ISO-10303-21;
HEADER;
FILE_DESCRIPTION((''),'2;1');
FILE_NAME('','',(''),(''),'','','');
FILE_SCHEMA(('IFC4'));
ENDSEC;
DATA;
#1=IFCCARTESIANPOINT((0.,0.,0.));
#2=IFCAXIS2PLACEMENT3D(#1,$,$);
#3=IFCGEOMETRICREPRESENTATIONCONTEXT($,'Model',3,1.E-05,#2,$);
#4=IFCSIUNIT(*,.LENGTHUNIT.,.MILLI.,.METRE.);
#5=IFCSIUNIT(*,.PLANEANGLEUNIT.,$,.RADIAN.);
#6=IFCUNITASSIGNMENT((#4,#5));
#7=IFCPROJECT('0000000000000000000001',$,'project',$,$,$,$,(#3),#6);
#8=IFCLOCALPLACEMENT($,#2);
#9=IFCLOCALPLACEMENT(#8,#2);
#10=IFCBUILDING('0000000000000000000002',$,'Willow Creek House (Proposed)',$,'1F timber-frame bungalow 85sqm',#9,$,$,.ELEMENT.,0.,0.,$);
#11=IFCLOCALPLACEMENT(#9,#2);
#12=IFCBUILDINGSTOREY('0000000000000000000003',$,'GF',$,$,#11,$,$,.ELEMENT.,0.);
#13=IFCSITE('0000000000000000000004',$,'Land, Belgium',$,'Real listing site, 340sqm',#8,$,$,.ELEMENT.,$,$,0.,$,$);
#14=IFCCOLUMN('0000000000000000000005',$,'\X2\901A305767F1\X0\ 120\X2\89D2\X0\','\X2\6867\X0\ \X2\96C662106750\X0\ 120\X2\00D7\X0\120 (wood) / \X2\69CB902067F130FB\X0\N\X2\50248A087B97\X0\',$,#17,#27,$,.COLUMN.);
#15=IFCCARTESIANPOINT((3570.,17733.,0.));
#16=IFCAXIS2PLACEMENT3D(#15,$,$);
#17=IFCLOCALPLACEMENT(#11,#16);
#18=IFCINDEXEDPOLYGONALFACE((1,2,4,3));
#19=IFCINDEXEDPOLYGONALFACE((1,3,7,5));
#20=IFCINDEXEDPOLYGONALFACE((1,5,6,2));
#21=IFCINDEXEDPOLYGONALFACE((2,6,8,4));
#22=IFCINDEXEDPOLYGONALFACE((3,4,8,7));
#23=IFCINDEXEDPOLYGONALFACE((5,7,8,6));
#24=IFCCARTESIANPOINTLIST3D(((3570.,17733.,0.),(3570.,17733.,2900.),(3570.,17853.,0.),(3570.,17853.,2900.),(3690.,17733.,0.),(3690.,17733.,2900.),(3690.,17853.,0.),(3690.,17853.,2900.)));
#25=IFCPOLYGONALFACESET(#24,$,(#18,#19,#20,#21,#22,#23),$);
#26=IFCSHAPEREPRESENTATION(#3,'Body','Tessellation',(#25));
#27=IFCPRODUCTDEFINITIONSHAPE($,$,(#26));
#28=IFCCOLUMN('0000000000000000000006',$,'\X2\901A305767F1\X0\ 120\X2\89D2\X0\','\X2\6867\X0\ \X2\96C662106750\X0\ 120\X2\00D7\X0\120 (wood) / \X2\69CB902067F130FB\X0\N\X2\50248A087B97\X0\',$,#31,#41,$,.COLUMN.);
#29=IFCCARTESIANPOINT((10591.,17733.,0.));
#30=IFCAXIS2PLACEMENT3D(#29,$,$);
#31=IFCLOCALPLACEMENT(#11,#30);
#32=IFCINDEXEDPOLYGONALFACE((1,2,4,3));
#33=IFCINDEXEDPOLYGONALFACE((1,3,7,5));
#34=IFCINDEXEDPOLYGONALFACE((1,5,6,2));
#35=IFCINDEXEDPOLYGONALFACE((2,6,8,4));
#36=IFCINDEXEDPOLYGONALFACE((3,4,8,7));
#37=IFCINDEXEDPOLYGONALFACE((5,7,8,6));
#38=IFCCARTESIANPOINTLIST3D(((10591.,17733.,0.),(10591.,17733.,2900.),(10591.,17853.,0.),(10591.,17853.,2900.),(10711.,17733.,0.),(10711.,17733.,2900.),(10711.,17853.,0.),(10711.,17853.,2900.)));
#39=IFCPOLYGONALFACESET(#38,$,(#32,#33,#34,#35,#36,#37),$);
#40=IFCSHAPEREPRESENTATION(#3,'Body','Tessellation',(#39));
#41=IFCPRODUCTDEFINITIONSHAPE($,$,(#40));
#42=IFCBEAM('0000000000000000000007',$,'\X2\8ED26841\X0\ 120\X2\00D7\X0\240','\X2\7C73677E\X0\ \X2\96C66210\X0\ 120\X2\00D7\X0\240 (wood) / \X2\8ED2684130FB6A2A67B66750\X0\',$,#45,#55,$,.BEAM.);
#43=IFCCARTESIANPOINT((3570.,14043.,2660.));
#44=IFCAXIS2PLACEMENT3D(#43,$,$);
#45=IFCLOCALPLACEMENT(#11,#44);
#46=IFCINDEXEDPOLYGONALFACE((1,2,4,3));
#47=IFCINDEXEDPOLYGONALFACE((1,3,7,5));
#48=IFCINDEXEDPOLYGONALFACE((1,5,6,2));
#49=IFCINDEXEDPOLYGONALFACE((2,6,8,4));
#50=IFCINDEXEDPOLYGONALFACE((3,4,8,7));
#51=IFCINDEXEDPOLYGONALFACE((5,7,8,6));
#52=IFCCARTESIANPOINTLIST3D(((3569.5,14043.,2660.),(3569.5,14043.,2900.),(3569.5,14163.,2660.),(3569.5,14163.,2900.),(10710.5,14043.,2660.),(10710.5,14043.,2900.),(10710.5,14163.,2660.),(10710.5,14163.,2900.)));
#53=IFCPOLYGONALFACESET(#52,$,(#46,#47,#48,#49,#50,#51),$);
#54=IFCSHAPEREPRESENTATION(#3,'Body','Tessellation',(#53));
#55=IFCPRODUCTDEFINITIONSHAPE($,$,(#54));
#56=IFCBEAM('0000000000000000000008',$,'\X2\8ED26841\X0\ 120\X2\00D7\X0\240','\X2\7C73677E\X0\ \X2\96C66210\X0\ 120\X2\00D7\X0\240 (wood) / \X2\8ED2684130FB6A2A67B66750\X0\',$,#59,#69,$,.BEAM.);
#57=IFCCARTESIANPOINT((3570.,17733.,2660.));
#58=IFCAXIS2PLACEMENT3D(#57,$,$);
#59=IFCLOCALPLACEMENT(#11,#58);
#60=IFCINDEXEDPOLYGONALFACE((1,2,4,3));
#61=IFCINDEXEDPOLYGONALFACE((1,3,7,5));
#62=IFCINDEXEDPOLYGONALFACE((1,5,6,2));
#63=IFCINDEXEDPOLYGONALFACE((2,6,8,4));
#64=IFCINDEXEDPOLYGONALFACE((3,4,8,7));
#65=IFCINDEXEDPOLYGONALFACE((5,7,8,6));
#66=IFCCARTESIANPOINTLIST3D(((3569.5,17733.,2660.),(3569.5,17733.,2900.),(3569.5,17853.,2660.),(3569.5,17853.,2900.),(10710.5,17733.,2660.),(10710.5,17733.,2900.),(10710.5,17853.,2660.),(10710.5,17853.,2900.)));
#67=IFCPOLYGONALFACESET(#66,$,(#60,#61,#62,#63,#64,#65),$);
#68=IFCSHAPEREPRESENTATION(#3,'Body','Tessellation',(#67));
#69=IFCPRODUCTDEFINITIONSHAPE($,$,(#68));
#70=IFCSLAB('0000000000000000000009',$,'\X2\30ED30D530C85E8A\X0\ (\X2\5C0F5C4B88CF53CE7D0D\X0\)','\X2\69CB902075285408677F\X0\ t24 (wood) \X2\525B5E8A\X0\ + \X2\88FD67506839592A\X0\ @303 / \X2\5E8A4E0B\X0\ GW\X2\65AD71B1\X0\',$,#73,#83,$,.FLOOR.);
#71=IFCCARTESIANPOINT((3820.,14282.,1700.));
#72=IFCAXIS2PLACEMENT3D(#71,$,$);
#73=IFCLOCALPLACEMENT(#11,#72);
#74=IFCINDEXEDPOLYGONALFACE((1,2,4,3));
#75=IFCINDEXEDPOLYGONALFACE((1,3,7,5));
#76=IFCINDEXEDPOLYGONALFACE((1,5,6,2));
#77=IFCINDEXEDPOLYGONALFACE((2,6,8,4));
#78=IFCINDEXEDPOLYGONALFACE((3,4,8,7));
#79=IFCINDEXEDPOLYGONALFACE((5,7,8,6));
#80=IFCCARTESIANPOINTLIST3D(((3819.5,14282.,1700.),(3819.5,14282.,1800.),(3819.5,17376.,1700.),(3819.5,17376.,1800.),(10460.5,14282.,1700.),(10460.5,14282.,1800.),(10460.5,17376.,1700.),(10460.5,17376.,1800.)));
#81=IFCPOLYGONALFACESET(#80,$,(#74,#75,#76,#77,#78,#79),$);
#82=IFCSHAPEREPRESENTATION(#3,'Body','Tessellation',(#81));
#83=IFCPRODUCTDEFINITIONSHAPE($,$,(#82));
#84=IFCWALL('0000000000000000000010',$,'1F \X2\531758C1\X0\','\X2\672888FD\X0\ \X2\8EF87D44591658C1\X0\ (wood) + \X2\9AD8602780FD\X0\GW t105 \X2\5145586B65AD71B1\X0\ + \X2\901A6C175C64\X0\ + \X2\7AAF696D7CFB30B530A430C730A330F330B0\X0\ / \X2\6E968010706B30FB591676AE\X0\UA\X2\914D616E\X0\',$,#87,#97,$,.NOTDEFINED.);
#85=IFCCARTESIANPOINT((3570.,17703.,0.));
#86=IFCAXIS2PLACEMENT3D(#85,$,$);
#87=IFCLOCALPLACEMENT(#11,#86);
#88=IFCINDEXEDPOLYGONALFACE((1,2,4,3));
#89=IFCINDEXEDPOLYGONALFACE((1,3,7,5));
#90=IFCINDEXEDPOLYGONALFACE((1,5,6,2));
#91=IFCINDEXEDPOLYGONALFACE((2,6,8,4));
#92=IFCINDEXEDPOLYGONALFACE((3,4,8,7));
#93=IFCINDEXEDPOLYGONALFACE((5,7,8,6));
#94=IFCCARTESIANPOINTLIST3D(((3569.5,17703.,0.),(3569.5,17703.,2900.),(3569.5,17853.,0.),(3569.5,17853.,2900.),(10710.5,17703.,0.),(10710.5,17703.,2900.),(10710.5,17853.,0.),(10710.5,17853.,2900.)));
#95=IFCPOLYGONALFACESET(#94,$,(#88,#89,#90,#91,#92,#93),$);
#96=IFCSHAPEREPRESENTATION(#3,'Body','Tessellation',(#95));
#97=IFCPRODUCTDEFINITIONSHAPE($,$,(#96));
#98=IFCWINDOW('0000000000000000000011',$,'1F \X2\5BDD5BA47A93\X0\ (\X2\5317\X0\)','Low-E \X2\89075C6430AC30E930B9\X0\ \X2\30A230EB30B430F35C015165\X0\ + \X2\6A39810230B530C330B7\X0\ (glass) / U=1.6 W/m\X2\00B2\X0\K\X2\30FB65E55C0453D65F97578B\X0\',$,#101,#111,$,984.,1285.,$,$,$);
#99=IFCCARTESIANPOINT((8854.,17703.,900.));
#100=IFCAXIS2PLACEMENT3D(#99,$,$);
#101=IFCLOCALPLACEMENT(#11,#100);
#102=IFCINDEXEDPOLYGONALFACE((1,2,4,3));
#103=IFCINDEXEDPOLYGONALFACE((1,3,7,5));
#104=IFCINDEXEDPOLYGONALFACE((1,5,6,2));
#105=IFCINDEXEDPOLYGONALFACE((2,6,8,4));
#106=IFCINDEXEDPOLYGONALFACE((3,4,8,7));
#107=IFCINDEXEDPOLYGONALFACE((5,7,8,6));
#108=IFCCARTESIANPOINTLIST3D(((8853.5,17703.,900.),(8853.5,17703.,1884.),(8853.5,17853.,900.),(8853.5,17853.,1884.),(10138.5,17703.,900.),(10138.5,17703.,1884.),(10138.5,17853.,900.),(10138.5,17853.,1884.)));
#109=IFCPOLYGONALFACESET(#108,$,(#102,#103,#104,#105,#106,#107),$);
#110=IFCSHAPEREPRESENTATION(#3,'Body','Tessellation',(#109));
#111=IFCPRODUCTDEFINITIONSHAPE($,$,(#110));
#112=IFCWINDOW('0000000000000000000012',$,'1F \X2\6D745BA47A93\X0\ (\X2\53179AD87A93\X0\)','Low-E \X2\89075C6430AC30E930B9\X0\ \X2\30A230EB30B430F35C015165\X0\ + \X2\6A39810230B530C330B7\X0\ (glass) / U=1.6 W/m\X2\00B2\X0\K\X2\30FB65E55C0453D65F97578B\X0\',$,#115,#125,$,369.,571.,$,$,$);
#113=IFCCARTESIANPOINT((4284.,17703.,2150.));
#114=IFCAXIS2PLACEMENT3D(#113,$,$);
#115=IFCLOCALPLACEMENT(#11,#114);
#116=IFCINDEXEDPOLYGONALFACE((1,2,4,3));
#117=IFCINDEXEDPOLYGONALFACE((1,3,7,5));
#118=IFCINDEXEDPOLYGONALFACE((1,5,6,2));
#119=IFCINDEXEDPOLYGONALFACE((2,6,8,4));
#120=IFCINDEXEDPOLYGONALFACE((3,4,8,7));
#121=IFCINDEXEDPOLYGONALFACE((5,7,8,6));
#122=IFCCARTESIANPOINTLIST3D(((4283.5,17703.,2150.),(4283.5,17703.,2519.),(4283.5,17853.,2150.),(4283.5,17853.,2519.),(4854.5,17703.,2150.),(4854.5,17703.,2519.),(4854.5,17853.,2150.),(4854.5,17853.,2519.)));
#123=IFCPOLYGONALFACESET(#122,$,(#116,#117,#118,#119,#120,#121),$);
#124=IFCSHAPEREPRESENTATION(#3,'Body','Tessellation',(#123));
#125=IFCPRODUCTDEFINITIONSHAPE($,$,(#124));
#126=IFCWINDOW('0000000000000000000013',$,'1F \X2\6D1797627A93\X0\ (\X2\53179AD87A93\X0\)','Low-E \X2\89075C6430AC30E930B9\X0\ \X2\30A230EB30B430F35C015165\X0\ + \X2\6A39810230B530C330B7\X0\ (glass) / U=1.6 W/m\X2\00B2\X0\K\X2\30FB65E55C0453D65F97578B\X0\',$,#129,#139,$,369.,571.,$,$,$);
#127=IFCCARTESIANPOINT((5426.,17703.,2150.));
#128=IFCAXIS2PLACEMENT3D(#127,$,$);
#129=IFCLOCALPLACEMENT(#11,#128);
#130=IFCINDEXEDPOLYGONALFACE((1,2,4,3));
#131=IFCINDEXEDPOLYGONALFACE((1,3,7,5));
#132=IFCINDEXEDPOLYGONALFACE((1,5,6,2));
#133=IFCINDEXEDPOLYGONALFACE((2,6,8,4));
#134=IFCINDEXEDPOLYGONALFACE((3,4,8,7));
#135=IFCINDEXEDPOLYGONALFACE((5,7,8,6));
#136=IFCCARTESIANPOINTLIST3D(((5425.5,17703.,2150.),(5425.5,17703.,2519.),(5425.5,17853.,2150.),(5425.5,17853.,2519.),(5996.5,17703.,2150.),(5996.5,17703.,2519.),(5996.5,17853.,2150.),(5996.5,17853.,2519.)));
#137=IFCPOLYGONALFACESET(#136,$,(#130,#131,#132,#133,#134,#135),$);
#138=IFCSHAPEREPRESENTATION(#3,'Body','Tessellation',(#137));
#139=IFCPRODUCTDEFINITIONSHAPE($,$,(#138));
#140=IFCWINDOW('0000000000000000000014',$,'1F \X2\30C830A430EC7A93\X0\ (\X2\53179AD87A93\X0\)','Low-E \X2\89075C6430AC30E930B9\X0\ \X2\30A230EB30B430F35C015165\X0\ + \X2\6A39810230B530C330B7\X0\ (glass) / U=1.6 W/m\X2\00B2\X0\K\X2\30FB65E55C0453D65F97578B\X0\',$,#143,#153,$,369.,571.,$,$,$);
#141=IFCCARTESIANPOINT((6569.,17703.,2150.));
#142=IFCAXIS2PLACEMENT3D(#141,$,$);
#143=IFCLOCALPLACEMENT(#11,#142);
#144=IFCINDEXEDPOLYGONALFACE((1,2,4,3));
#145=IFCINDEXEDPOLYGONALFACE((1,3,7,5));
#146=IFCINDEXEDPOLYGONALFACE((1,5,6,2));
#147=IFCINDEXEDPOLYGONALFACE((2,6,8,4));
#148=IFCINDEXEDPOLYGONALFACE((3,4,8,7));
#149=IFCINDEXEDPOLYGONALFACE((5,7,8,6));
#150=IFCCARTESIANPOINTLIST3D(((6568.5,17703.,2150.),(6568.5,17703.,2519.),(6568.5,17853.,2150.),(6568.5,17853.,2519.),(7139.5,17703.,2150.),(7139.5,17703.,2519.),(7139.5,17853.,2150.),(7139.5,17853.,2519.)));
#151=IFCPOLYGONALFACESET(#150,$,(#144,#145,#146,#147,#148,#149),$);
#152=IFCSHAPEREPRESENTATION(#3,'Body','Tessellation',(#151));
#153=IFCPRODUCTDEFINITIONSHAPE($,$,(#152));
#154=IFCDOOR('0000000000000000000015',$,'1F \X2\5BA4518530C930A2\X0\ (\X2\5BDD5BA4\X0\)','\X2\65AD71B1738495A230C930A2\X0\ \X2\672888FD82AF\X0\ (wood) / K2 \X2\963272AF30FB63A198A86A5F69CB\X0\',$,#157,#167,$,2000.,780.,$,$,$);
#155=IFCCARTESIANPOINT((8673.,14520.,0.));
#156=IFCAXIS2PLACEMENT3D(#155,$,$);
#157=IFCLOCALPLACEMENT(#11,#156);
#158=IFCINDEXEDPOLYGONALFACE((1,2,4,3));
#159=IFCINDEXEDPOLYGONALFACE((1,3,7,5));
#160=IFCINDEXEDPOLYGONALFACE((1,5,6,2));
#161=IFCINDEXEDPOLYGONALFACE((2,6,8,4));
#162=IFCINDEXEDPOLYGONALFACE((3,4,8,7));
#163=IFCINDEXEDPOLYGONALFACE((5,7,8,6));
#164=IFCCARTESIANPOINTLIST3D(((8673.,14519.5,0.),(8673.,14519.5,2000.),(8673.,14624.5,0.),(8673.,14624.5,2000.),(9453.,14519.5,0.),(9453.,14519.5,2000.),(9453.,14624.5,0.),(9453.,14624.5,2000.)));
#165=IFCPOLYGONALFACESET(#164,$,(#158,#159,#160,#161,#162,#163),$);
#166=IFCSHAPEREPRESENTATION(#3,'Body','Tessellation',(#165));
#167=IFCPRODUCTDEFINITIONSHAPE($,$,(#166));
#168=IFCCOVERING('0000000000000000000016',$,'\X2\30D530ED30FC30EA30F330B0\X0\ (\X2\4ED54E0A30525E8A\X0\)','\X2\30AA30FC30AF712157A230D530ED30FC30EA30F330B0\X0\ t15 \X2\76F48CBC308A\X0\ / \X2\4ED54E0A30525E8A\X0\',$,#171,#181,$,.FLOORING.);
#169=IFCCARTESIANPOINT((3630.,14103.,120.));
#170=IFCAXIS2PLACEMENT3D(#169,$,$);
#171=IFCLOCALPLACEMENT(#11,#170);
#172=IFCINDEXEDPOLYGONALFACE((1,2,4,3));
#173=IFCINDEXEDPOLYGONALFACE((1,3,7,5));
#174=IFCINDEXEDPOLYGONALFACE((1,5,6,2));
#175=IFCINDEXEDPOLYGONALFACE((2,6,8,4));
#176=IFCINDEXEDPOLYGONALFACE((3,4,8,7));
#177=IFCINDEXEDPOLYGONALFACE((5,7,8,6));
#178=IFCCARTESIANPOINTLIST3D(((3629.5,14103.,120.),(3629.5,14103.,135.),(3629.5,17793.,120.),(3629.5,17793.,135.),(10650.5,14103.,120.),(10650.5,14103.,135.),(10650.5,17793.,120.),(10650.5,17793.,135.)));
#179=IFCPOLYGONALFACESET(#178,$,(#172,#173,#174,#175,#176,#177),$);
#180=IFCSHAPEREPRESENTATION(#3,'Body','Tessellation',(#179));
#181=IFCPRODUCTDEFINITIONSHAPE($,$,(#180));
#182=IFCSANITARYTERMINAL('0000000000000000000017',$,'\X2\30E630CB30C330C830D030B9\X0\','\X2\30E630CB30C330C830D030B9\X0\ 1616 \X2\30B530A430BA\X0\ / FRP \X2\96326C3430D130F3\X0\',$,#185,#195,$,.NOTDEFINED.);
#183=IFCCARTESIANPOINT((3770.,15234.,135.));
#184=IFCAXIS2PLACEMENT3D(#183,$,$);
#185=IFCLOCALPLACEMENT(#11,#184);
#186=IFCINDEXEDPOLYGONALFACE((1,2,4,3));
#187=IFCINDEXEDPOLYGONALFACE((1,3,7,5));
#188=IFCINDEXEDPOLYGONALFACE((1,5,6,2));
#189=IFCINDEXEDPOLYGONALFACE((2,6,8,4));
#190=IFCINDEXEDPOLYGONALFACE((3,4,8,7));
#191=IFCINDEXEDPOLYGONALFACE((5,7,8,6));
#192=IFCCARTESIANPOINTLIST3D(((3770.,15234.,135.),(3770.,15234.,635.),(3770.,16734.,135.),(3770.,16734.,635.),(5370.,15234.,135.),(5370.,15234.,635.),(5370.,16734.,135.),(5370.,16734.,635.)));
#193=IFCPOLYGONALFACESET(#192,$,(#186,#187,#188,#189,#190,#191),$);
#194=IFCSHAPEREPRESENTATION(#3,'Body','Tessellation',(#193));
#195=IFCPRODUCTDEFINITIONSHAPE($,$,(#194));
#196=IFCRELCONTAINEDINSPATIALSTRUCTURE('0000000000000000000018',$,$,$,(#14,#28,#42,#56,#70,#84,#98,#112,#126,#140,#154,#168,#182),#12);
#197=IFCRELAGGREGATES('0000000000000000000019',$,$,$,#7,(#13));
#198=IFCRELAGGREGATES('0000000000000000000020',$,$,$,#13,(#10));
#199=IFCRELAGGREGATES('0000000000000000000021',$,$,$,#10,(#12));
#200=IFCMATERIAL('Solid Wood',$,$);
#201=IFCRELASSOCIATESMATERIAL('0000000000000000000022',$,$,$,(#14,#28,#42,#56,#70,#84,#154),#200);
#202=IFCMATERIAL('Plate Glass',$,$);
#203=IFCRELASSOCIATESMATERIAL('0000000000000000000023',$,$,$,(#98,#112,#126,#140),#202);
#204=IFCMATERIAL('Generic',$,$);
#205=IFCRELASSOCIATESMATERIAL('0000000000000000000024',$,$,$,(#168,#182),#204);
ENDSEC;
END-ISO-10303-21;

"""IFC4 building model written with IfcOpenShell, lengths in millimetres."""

from ifc_helpers import new_model, si_unit, frame, frame_2d, origin, place, context, project, spatial, rectangle, extrude, material, element, fill, save


model = new_model("IFC4")

# Units and contexts
model_context = context("Model", 3, precision=1e-05, world=origin())
ifc_project = project(units=[si_unit("LENGTHUNIT", "METRE", prefix="MILLI"), si_unit("PLANEANGLEUNIT", "RADIAN")], contexts=[model_context])

# Site, building, storey
site_placement = place(None, origin())
site = spatial("IfcSite", under=ifc_project, at=site_placement, Name="Land, Belgium", ObjectType="Real listing site, 340sqm", CompositionType="ELEMENT", RefElevation=0.0)
building_placement = place(site_placement, origin())
building = spatial("IfcBuilding", under=site, at=building_placement, Name="Willow Creek House (Proposed)", ObjectType="1F timber-frame bungalow 85sqm", CompositionType="ELEMENT", ElevationOfRefHeight=0.0, ElevationOfTerrain=0.0)
storey_placement = place(building_placement, origin())
storey = spatial("IfcBuildingStorey", under=building, at=storey_placement, Name="GF", CompositionType="ELEMENT", Elevation=0.0)

# Columns
ifc_material_1 = material(Name="Solid Wood")
column_1_placement = place(storey_placement, frame((3570.0, 17733.0, 0.0)))
element("IfcColumn", 1, at=column_1_placement, inside=storey, material=ifc_material_1, Name="通し柱 120角", Description="桧 集成材 120×120 (wood) / 構造柱・N値計算", PredefinedType="COLUMN", context=model_context, shape_type="SweptSolid", body=[
    extrude(rectangle(XDim=120.0, YDim=120.0, at=frame_2d((60.0, 60.0))), frame((3570.0, 17733.0, 0.0)), (0.0, 0.0, 1.0), 2900.0),
])
column_2_placement = place(storey_placement, frame((10591.0, 17733.0, 0.0)))
element("IfcColumn", 2, at=column_2_placement, inside=storey, material=ifc_material_1, Name="通し柱 120角", Description="桧 集成材 120×120 (wood) / 構造柱・N値計算", PredefinedType="COLUMN", context=model_context, shape_type="SweptSolid", body=[
    extrude(rectangle(XDim=120.0, YDim=120.0, at=frame_2d((60.0, 60.0))), frame((10591.0, 17733.0, 0.0)), (0.0, 0.0, 1.0), 2900.0),
])

# Beams
beam_1_placement = place(storey_placement, frame((3570.0, 14043.0, 2660.0)))
element("IfcBeam", 3, at=beam_1_placement, inside=storey, material=ifc_material_1, Name="軒桁 120×240", Description="米松 集成 120×240 (wood) / 軒桁・横架材", PredefinedType="BEAM", context=model_context, shape_type="SweptSolid", body=[
    extrude(rectangle(XDim=7141.0, YDim=120.0, at=frame_2d((3570.0, 60.0))), frame((3570.0, 14043.0, 2660.0)), (0.0, 0.0, 1.0), 240.0),
])
beam_2_placement = place(storey_placement, frame((3570.0, 17733.0, 2660.0)))
element("IfcBeam", 4, at=beam_2_placement, inside=storey, material=ifc_material_1, Name="軒桁 120×240", Description="米松 集成 120×240 (wood) / 軒桁・横架材", PredefinedType="BEAM", context=model_context, shape_type="SweptSolid", body=[
    extrude(rectangle(XDim=7141.0, YDim=120.0, at=frame_2d((3570.0, 60.0))), frame((3570.0, 17733.0, 2660.0)), (0.0, 0.0, 1.0), 240.0),
])

# Slab
slab_placement = place(storey_placement, frame((3820.0, 14282.0, 1700.0)))
element("IfcSlab", 5, at=slab_placement, inside=storey, material=ifc_material_1, Name="ロフト床 (小屋裏収納)", Description="構造用合板 t24 (wood) 剛床 + 製材根太 @303 / 床下 GW断熱", PredefinedType="FLOOR", context=model_context, shape_type="SweptSolid", body=[
    extrude(rectangle(XDim=6641.0, YDim=3094.0, at=frame_2d((3320.0, 1547.0))), frame((3820.0, 14282.0, 1700.0)), (0.0, 0.0, 1.0), 100.0),
])

# Wall, openings, windows
wall_1_placement = place(storey_placement, frame((3570.0, 17703.0, 0.0)))
wall_1 = element("IfcWall", 6, at=wall_1_placement, inside=storey, material=ifc_material_1, Name="1F 北壁", Description="木製 軸組外壁 (wood) + 高性能GW t105 充填断熱 + 通気層 + 窯業系サイディング / 準耐火・外皮UA配慮", PredefinedType="NOTDEFINED", context=model_context, shape_type="SweptSolid", body=[
    extrude(rectangle(XDim=7141.0, YDim=150.0, at=frame_2d((3570.0, 75.0))), frame((3570.0, 17703.0, 0.0)), (0.0, 0.0, 1.0), 2900.0),
])
opening_1_placement = place(storey_placement, frame((8854.0, 17703.0, 900.0)))
opening_1 = element("IfcOpeningElement", 7, at=opening_1_placement, cuts=wall_1, PredefinedType="NOTDEFINED", context=model_context, shape_type="SweptSolid", body=[
    extrude(rectangle(XDim=1285.0, YDim=150.0, at=frame_2d((642.0, 75.0))), frame((8854.0, 17703.0, 900.0)), (0.0, 0.0, 1.0), 984.0),
])
opening_2_placement = place(storey_placement, frame((4284.0, 17703.0, 2150.0)))
opening_2 = element("IfcOpeningElement", 8, at=opening_2_placement, cuts=wall_1, PredefinedType="NOTDEFINED", context=model_context, shape_type="SweptSolid", body=[
    extrude(rectangle(XDim=571.0, YDim=150.0, at=frame_2d((285.0, 75.0))), frame((4284.0, 17703.0, 2150.0)), (0.0, 0.0, 1.0), 369.0),
])
opening_3_placement = place(storey_placement, frame((5426.0, 17703.0, 2150.0)))
opening_3 = element("IfcOpeningElement", 9, at=opening_3_placement, cuts=wall_1, PredefinedType="NOTDEFINED", context=model_context, shape_type="SweptSolid", body=[
    extrude(rectangle(XDim=571.0, YDim=150.0, at=frame_2d((285.0, 75.0))), frame((5426.0, 17703.0, 2150.0)), (0.0, 0.0, 1.0), 369.0),
])
opening_4_placement = place(storey_placement, frame((6569.0, 17703.0, 2150.0)))
opening_4 = element("IfcOpeningElement", 10, at=opening_4_placement, cuts=wall_1, PredefinedType="NOTDEFINED", context=model_context, shape_type="SweptSolid", body=[
    extrude(rectangle(XDim=571.0, YDim=150.0, at=frame_2d((285.0, 75.0))), frame((6569.0, 17703.0, 2150.0)), (0.0, 0.0, 1.0), 369.0),
])
ifc_material_2 = material(Name="Plate Glass")
window_1_placement = place(storey_placement, frame((8854.0, 17703.0, 900.0)))
window_1 = element("IfcWindow", 11, at=window_1_placement, inside=storey, material=ifc_material_2, Name="1F 寝室窓 (北)", Description="Low-E 複層ガラス アルゴン封入 + 樹脂サッシ (glass) / U=1.6 W/m²K・日射取得型", OverallHeight=984.0, OverallWidth=1285.0, context=model_context, shape_type="SweptSolid", body=[
    extrude(rectangle(XDim=1285.0, YDim=150.0, at=frame_2d((642.0, 75.0))), frame((8854.0, 17703.0, 900.0)), (0.0, 0.0, 1.0), 984.0),
])
fill(opening_1, window_1)
window_2_placement = place(storey_placement, frame((4284.0, 17703.0, 2150.0)))
window_2 = element("IfcWindow", 12, at=window_2_placement, inside=storey, material=ifc_material_2, Name="1F 浴室窓 (北高窓)", Description="Low-E 複層ガラス アルゴン封入 + 樹脂サッシ (glass) / U=1.6 W/m²K・日射取得型", OverallHeight=369.0, OverallWidth=571.0, context=model_context, shape_type="SweptSolid", body=[
    extrude(rectangle(XDim=571.0, YDim=150.0, at=frame_2d((285.0, 75.0))), frame((4284.0, 17703.0, 2150.0)), (0.0, 0.0, 1.0), 369.0),
])
fill(opening_2, window_2)
window_3_placement = place(storey_placement, frame((5426.0, 17703.0, 2150.0)))
window_3 = element("IfcWindow", 13, at=window_3_placement, inside=storey, material=ifc_material_2, Name="1F 洗面窓 (北高窓)", Description="Low-E 複層ガラス アルゴン封入 + 樹脂サッシ (glass) / U=1.6 W/m²K・日射取得型", OverallHeight=369.0, OverallWidth=571.0, context=model_context, shape_type="SweptSolid", body=[
    extrude(rectangle(XDim=571.0, YDim=150.0, at=frame_2d((285.0, 75.0))), frame((5426.0, 17703.0, 2150.0)), (0.0, 0.0, 1.0), 369.0),
])
fill(opening_3, window_3)
window_4_placement = place(storey_placement, frame((6569.0, 17703.0, 2150.0)))
window_4 = element("IfcWindow", 14, at=window_4_placement, inside=storey, material=ifc_material_2, Name="1F トイレ窓 (北高窓)", Description="Low-E 複層ガラス アルゴン封入 + 樹脂サッシ (glass) / U=1.6 W/m²K・日射取得型", OverallHeight=369.0, OverallWidth=571.0, context=model_context, shape_type="SweptSolid", body=[
    extrude(rectangle(XDim=571.0, YDim=150.0, at=frame_2d((285.0, 75.0))), frame((6569.0, 17703.0, 2150.0)), (0.0, 0.0, 1.0), 369.0),
])
fill(opening_4, window_4)

# Door
door_1_placement = place(storey_placement, frame((8673.0, 14520.0, 0.0)))
element("IfcDoor", 15, at=door_1_placement, inside=storey, material=ifc_material_1, Name="1F 室内ドア (寝室)", Description="断熱玄関ドア 木製芯 (wood) / K2 防犯・採風機構", OverallHeight=2000.0, OverallWidth=780.0, context=model_context, shape_type="SweptSolid", body=[
    extrude(rectangle(XDim=780.0, YDim=105.0, at=frame_2d((390.0, 52.0))), frame((8673.0, 14520.0, 0.0)), (0.0, 0.0, 1.0), 2000.0),
])

# Covering
ifc_material_3 = material(Name="Generic")
covering_placement = place(storey_placement, frame((3630.0, 14103.0, 120.0)))
element("IfcCovering", 16, at=covering_placement, inside=storey, material=ifc_material_3, Name="フローリング (仕上げ床)", Description="オーク無垢フローリング t15 直貼り / 仕上げ床", PredefinedType="FLOORING", context=model_context, shape_type="SweptSolid", body=[
    extrude(rectangle(XDim=7021.0, YDim=3690.0, at=frame_2d((3510.0, 1845.0))), frame((3630.0, 14103.0, 120.0)), (0.0, 0.0, 1.0), 15.0),
])

# Sanitary terminal
sanitary_terminal_1_placement = place(storey_placement, frame((3770.0, 15234.0, 135.0)))
element("IfcSanitaryTerminal", 17, at=sanitary_terminal_1_placement, inside=storey, material=ifc_material_3, Name="ユニットバス", Description="ユニットバス 1616 サイズ / FRP 防水パン", PredefinedType="NOTDEFINED", context=model_context, shape_type="SweptSolid", body=[
    extrude(rectangle(XDim=1600.0, YDim=1500.0, at=frame_2d((800.0, 750.0))), frame((3770.0, 15234.0, 135.0)), (0.0, 0.0, 1.0), 500.0),
])

save(model, "model.ifc")
